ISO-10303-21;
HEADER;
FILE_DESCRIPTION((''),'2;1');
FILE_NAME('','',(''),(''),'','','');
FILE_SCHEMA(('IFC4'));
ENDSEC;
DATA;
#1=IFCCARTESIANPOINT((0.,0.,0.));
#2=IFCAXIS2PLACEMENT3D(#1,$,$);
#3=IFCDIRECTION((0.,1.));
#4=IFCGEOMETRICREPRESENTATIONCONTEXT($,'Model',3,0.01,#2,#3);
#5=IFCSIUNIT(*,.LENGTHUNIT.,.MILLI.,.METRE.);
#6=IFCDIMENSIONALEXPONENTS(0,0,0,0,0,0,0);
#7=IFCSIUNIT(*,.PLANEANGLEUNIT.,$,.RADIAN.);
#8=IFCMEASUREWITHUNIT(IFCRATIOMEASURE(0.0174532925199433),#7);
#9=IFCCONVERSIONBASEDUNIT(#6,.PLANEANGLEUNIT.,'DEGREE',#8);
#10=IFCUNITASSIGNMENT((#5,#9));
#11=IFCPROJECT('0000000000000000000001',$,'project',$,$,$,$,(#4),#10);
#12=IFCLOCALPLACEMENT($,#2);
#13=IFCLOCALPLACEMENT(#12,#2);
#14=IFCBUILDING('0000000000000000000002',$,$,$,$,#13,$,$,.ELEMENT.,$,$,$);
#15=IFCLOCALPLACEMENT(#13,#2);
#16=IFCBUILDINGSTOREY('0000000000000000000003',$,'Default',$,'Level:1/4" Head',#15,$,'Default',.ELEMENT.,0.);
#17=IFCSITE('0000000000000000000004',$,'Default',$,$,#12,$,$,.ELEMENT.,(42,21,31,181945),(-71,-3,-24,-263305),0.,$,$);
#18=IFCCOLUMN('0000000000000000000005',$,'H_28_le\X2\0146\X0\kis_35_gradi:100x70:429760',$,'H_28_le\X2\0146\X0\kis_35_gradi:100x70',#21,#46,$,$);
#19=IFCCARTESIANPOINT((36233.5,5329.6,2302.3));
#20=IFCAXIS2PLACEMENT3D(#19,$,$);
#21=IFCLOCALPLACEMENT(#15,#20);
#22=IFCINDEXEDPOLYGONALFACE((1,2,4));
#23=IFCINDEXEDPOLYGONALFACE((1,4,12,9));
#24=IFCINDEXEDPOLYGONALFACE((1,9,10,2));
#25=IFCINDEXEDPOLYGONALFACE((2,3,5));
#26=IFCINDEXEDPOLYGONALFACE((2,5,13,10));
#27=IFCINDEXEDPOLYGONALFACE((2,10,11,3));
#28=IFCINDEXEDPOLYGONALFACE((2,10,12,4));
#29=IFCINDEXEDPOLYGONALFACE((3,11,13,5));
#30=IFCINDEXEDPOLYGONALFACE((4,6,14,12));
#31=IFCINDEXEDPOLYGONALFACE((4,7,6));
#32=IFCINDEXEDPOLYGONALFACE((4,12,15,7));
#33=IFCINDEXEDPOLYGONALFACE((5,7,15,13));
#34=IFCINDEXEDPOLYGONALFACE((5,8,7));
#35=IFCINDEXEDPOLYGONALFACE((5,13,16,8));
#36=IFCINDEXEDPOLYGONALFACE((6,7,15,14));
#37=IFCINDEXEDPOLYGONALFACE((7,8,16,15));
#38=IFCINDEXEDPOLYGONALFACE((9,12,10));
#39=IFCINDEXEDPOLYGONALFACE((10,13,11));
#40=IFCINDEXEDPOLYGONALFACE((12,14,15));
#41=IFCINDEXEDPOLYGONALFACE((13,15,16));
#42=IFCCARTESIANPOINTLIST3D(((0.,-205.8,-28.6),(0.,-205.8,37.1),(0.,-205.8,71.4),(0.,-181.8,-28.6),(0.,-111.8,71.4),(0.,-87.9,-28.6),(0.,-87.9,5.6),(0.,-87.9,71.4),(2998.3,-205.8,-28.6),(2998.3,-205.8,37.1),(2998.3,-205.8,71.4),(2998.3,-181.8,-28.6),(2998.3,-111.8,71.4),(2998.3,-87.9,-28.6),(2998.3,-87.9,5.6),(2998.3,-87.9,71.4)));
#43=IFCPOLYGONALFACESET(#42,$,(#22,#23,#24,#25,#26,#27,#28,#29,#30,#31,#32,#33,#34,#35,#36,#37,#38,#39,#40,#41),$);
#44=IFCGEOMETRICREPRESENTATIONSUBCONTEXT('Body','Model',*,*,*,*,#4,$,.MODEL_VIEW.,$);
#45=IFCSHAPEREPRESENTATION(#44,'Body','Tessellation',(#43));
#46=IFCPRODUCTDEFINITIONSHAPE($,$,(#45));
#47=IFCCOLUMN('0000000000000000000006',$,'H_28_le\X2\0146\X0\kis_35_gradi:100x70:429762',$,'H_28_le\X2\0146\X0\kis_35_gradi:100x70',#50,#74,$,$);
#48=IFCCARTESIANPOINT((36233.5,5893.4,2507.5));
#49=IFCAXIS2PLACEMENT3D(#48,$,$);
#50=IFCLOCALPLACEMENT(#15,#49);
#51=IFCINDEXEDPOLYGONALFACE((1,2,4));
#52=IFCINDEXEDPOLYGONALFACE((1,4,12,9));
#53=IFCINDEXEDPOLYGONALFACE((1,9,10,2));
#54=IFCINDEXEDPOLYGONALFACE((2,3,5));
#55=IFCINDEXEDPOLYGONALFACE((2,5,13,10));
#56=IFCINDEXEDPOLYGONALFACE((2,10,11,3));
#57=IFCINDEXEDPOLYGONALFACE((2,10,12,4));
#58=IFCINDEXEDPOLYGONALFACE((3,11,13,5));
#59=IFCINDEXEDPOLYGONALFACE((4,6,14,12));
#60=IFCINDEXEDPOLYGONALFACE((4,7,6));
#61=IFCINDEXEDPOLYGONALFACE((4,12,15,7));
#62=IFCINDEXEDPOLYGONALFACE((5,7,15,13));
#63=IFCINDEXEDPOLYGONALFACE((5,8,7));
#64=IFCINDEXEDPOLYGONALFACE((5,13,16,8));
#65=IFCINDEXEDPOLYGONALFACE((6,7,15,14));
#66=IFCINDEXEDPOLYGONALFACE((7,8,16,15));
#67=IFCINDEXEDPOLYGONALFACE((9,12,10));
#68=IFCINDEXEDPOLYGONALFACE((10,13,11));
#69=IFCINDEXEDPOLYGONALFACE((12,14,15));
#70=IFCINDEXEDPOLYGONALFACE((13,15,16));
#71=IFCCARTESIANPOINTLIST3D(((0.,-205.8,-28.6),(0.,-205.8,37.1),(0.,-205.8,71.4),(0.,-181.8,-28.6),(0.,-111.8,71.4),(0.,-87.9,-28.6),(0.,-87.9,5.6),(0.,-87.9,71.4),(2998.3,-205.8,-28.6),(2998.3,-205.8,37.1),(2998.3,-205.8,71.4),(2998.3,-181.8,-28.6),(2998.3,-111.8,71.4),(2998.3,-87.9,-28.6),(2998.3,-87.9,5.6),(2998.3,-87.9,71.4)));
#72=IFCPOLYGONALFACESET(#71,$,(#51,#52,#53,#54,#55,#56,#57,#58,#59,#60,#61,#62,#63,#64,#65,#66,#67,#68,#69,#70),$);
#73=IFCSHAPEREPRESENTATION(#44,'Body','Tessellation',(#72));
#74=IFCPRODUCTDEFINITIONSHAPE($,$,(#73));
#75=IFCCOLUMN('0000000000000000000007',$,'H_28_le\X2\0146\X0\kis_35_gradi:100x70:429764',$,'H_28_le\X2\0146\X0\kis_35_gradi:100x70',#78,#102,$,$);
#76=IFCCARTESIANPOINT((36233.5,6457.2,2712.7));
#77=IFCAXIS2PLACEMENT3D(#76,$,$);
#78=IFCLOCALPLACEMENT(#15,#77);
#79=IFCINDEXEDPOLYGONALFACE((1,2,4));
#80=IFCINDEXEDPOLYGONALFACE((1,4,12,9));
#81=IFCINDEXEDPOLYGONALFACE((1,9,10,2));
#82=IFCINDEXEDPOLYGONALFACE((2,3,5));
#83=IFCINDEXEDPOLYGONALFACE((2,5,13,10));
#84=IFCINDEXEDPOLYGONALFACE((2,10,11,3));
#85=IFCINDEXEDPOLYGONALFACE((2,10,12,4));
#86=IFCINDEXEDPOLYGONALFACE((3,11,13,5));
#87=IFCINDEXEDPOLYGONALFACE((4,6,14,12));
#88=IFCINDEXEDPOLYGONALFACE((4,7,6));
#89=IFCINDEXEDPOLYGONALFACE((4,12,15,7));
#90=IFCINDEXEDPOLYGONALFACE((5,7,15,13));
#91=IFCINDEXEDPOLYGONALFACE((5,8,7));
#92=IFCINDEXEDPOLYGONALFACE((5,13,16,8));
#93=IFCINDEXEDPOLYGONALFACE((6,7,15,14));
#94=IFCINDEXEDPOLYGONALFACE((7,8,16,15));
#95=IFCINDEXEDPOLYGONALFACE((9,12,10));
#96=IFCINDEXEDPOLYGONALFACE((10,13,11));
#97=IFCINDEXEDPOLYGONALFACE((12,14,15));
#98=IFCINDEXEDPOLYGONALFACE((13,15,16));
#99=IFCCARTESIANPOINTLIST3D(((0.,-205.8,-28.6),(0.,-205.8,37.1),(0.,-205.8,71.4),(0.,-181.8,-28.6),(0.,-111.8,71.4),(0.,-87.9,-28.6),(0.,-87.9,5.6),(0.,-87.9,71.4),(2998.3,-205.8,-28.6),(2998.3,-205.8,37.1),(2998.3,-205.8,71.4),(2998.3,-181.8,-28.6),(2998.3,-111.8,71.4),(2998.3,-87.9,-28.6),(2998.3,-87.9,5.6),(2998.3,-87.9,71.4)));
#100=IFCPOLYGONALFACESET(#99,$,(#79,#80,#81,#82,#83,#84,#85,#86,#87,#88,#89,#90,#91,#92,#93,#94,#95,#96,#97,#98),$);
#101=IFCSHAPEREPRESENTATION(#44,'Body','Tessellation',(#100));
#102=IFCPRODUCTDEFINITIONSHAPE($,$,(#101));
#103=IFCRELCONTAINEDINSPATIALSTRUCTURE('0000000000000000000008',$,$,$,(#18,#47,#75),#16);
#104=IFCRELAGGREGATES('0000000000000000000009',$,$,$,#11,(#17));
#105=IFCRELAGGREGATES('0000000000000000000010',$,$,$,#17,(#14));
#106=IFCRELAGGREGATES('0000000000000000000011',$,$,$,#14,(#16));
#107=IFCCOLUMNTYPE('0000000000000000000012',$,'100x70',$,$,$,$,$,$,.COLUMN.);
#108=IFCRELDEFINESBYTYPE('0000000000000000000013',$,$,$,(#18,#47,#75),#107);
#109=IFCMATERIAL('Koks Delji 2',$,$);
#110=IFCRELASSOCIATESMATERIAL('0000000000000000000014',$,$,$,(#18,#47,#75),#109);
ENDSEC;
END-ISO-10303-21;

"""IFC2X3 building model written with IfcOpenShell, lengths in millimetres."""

from ifc_helpers import new_model, entity, si_unit, converted_unit, direction, frame, frame_2d, origin, place, context, subcontext, project, spatial, rectangle, extrude, boolean, source, transform, mapped, material, type_object, type_shapes, element, save


model = new_model("IFC2X3")

# Units and contexts
model_context = context("Model", 3, precision=0.01, world=origin(), true_north=direction((0.0, 1.0)))
body_context = subcontext(model_context, "Body", "Model", "MODEL_VIEW")
ifc_project = project(units=[si_unit("LENGTHUNIT", "METRE", prefix="MILLI"), converted_unit("PLANEANGLEUNIT", "DEGREE", entity("IfcRatioMeasure", 0.0174532925199433), si_unit("PLANEANGLEUNIT", "RADIAN"), dimensions=[0, 0, 0, 0, 0, 0, 0])], contexts=[model_context])

# Site, building, storey
site_placement = place(None, origin())
site = spatial("IfcSite", under=ifc_project, at=site_placement, Name="Default", CompositionType="ELEMENT", RefLatitude=(42, 21, 31, 181945), RefLongitude=(-71, -3, -24, -263305), RefElevation=0.0)
building_placement = place(site_placement, origin())
building = spatial("IfcBuilding", under=site, at=building_placement, CompositionType="ELEMENT")
storey_placement = place(building_placement, origin())
storey = spatial("IfcBuildingStorey", under=building, at=storey_placement, Name="Default", ObjectType="Level:1/4\" Head", LongName="Default", CompositionType="ELEMENT", Elevation=0.0)

# Columns
ifc_material_1 = material(Name="Koks Delji 2")
column_type = type_object("IfcColumnType", Name="100x70", PredefinedType="COLUMN")
shared_shape_1 = source(origin(), body_context, "Body", "CSG", [
    boolean("DIFFERENCE", extrude(rectangle(XDim=2998.3, YDim=117.9, at=frame_2d((0.0, 0.0), x_axis=(1.0, 0.0))), frame((1499.1, -146.8, -28.6)), (0.0, 0.0, 1.0), 100.0), extrude(rectangle(XDim=70.0, YDim=100.0, at=frame_2d((0.0, 0.0), x_axis=(0.0, 1.0))), frame((0.0, -146.8, 21.4), z_axis=(-1.0, 0.0, 0.0), x_axis=(0.0, -0.939693, -0.34202)), (0.0, 0.0, -1.0), 2998.3)),
])
type_shapes(column_type, [shared_shape_1])
for number, where, name in (
    (1, (36233.5, 5329.6, 2302.3), "H_28_leņkis_35_gradi:100x70:429760"),
    (2, (36233.5, 5893.4, 2507.5), "H_28_leņkis_35_gradi:100x70:429762"),
    (3, (36233.5, 6457.2, 2712.7), "H_28_leņkis_35_gradi:100x70:429764"),
):
    element("IfcColumn", number, at=place(storey_placement, frame(where)), inside=storey, type_object=column_type, material=ifc_material_1, Name=name, ObjectType="H_28_leņkis_35_gradi:100x70", context=body_context, shape_type="MappedRepresentation", body=[
        mapped(shared_shape_1, transform((0.0, 0.0, 0.0), scale=1.0)),
    ])

save(model, "model.ifc")
